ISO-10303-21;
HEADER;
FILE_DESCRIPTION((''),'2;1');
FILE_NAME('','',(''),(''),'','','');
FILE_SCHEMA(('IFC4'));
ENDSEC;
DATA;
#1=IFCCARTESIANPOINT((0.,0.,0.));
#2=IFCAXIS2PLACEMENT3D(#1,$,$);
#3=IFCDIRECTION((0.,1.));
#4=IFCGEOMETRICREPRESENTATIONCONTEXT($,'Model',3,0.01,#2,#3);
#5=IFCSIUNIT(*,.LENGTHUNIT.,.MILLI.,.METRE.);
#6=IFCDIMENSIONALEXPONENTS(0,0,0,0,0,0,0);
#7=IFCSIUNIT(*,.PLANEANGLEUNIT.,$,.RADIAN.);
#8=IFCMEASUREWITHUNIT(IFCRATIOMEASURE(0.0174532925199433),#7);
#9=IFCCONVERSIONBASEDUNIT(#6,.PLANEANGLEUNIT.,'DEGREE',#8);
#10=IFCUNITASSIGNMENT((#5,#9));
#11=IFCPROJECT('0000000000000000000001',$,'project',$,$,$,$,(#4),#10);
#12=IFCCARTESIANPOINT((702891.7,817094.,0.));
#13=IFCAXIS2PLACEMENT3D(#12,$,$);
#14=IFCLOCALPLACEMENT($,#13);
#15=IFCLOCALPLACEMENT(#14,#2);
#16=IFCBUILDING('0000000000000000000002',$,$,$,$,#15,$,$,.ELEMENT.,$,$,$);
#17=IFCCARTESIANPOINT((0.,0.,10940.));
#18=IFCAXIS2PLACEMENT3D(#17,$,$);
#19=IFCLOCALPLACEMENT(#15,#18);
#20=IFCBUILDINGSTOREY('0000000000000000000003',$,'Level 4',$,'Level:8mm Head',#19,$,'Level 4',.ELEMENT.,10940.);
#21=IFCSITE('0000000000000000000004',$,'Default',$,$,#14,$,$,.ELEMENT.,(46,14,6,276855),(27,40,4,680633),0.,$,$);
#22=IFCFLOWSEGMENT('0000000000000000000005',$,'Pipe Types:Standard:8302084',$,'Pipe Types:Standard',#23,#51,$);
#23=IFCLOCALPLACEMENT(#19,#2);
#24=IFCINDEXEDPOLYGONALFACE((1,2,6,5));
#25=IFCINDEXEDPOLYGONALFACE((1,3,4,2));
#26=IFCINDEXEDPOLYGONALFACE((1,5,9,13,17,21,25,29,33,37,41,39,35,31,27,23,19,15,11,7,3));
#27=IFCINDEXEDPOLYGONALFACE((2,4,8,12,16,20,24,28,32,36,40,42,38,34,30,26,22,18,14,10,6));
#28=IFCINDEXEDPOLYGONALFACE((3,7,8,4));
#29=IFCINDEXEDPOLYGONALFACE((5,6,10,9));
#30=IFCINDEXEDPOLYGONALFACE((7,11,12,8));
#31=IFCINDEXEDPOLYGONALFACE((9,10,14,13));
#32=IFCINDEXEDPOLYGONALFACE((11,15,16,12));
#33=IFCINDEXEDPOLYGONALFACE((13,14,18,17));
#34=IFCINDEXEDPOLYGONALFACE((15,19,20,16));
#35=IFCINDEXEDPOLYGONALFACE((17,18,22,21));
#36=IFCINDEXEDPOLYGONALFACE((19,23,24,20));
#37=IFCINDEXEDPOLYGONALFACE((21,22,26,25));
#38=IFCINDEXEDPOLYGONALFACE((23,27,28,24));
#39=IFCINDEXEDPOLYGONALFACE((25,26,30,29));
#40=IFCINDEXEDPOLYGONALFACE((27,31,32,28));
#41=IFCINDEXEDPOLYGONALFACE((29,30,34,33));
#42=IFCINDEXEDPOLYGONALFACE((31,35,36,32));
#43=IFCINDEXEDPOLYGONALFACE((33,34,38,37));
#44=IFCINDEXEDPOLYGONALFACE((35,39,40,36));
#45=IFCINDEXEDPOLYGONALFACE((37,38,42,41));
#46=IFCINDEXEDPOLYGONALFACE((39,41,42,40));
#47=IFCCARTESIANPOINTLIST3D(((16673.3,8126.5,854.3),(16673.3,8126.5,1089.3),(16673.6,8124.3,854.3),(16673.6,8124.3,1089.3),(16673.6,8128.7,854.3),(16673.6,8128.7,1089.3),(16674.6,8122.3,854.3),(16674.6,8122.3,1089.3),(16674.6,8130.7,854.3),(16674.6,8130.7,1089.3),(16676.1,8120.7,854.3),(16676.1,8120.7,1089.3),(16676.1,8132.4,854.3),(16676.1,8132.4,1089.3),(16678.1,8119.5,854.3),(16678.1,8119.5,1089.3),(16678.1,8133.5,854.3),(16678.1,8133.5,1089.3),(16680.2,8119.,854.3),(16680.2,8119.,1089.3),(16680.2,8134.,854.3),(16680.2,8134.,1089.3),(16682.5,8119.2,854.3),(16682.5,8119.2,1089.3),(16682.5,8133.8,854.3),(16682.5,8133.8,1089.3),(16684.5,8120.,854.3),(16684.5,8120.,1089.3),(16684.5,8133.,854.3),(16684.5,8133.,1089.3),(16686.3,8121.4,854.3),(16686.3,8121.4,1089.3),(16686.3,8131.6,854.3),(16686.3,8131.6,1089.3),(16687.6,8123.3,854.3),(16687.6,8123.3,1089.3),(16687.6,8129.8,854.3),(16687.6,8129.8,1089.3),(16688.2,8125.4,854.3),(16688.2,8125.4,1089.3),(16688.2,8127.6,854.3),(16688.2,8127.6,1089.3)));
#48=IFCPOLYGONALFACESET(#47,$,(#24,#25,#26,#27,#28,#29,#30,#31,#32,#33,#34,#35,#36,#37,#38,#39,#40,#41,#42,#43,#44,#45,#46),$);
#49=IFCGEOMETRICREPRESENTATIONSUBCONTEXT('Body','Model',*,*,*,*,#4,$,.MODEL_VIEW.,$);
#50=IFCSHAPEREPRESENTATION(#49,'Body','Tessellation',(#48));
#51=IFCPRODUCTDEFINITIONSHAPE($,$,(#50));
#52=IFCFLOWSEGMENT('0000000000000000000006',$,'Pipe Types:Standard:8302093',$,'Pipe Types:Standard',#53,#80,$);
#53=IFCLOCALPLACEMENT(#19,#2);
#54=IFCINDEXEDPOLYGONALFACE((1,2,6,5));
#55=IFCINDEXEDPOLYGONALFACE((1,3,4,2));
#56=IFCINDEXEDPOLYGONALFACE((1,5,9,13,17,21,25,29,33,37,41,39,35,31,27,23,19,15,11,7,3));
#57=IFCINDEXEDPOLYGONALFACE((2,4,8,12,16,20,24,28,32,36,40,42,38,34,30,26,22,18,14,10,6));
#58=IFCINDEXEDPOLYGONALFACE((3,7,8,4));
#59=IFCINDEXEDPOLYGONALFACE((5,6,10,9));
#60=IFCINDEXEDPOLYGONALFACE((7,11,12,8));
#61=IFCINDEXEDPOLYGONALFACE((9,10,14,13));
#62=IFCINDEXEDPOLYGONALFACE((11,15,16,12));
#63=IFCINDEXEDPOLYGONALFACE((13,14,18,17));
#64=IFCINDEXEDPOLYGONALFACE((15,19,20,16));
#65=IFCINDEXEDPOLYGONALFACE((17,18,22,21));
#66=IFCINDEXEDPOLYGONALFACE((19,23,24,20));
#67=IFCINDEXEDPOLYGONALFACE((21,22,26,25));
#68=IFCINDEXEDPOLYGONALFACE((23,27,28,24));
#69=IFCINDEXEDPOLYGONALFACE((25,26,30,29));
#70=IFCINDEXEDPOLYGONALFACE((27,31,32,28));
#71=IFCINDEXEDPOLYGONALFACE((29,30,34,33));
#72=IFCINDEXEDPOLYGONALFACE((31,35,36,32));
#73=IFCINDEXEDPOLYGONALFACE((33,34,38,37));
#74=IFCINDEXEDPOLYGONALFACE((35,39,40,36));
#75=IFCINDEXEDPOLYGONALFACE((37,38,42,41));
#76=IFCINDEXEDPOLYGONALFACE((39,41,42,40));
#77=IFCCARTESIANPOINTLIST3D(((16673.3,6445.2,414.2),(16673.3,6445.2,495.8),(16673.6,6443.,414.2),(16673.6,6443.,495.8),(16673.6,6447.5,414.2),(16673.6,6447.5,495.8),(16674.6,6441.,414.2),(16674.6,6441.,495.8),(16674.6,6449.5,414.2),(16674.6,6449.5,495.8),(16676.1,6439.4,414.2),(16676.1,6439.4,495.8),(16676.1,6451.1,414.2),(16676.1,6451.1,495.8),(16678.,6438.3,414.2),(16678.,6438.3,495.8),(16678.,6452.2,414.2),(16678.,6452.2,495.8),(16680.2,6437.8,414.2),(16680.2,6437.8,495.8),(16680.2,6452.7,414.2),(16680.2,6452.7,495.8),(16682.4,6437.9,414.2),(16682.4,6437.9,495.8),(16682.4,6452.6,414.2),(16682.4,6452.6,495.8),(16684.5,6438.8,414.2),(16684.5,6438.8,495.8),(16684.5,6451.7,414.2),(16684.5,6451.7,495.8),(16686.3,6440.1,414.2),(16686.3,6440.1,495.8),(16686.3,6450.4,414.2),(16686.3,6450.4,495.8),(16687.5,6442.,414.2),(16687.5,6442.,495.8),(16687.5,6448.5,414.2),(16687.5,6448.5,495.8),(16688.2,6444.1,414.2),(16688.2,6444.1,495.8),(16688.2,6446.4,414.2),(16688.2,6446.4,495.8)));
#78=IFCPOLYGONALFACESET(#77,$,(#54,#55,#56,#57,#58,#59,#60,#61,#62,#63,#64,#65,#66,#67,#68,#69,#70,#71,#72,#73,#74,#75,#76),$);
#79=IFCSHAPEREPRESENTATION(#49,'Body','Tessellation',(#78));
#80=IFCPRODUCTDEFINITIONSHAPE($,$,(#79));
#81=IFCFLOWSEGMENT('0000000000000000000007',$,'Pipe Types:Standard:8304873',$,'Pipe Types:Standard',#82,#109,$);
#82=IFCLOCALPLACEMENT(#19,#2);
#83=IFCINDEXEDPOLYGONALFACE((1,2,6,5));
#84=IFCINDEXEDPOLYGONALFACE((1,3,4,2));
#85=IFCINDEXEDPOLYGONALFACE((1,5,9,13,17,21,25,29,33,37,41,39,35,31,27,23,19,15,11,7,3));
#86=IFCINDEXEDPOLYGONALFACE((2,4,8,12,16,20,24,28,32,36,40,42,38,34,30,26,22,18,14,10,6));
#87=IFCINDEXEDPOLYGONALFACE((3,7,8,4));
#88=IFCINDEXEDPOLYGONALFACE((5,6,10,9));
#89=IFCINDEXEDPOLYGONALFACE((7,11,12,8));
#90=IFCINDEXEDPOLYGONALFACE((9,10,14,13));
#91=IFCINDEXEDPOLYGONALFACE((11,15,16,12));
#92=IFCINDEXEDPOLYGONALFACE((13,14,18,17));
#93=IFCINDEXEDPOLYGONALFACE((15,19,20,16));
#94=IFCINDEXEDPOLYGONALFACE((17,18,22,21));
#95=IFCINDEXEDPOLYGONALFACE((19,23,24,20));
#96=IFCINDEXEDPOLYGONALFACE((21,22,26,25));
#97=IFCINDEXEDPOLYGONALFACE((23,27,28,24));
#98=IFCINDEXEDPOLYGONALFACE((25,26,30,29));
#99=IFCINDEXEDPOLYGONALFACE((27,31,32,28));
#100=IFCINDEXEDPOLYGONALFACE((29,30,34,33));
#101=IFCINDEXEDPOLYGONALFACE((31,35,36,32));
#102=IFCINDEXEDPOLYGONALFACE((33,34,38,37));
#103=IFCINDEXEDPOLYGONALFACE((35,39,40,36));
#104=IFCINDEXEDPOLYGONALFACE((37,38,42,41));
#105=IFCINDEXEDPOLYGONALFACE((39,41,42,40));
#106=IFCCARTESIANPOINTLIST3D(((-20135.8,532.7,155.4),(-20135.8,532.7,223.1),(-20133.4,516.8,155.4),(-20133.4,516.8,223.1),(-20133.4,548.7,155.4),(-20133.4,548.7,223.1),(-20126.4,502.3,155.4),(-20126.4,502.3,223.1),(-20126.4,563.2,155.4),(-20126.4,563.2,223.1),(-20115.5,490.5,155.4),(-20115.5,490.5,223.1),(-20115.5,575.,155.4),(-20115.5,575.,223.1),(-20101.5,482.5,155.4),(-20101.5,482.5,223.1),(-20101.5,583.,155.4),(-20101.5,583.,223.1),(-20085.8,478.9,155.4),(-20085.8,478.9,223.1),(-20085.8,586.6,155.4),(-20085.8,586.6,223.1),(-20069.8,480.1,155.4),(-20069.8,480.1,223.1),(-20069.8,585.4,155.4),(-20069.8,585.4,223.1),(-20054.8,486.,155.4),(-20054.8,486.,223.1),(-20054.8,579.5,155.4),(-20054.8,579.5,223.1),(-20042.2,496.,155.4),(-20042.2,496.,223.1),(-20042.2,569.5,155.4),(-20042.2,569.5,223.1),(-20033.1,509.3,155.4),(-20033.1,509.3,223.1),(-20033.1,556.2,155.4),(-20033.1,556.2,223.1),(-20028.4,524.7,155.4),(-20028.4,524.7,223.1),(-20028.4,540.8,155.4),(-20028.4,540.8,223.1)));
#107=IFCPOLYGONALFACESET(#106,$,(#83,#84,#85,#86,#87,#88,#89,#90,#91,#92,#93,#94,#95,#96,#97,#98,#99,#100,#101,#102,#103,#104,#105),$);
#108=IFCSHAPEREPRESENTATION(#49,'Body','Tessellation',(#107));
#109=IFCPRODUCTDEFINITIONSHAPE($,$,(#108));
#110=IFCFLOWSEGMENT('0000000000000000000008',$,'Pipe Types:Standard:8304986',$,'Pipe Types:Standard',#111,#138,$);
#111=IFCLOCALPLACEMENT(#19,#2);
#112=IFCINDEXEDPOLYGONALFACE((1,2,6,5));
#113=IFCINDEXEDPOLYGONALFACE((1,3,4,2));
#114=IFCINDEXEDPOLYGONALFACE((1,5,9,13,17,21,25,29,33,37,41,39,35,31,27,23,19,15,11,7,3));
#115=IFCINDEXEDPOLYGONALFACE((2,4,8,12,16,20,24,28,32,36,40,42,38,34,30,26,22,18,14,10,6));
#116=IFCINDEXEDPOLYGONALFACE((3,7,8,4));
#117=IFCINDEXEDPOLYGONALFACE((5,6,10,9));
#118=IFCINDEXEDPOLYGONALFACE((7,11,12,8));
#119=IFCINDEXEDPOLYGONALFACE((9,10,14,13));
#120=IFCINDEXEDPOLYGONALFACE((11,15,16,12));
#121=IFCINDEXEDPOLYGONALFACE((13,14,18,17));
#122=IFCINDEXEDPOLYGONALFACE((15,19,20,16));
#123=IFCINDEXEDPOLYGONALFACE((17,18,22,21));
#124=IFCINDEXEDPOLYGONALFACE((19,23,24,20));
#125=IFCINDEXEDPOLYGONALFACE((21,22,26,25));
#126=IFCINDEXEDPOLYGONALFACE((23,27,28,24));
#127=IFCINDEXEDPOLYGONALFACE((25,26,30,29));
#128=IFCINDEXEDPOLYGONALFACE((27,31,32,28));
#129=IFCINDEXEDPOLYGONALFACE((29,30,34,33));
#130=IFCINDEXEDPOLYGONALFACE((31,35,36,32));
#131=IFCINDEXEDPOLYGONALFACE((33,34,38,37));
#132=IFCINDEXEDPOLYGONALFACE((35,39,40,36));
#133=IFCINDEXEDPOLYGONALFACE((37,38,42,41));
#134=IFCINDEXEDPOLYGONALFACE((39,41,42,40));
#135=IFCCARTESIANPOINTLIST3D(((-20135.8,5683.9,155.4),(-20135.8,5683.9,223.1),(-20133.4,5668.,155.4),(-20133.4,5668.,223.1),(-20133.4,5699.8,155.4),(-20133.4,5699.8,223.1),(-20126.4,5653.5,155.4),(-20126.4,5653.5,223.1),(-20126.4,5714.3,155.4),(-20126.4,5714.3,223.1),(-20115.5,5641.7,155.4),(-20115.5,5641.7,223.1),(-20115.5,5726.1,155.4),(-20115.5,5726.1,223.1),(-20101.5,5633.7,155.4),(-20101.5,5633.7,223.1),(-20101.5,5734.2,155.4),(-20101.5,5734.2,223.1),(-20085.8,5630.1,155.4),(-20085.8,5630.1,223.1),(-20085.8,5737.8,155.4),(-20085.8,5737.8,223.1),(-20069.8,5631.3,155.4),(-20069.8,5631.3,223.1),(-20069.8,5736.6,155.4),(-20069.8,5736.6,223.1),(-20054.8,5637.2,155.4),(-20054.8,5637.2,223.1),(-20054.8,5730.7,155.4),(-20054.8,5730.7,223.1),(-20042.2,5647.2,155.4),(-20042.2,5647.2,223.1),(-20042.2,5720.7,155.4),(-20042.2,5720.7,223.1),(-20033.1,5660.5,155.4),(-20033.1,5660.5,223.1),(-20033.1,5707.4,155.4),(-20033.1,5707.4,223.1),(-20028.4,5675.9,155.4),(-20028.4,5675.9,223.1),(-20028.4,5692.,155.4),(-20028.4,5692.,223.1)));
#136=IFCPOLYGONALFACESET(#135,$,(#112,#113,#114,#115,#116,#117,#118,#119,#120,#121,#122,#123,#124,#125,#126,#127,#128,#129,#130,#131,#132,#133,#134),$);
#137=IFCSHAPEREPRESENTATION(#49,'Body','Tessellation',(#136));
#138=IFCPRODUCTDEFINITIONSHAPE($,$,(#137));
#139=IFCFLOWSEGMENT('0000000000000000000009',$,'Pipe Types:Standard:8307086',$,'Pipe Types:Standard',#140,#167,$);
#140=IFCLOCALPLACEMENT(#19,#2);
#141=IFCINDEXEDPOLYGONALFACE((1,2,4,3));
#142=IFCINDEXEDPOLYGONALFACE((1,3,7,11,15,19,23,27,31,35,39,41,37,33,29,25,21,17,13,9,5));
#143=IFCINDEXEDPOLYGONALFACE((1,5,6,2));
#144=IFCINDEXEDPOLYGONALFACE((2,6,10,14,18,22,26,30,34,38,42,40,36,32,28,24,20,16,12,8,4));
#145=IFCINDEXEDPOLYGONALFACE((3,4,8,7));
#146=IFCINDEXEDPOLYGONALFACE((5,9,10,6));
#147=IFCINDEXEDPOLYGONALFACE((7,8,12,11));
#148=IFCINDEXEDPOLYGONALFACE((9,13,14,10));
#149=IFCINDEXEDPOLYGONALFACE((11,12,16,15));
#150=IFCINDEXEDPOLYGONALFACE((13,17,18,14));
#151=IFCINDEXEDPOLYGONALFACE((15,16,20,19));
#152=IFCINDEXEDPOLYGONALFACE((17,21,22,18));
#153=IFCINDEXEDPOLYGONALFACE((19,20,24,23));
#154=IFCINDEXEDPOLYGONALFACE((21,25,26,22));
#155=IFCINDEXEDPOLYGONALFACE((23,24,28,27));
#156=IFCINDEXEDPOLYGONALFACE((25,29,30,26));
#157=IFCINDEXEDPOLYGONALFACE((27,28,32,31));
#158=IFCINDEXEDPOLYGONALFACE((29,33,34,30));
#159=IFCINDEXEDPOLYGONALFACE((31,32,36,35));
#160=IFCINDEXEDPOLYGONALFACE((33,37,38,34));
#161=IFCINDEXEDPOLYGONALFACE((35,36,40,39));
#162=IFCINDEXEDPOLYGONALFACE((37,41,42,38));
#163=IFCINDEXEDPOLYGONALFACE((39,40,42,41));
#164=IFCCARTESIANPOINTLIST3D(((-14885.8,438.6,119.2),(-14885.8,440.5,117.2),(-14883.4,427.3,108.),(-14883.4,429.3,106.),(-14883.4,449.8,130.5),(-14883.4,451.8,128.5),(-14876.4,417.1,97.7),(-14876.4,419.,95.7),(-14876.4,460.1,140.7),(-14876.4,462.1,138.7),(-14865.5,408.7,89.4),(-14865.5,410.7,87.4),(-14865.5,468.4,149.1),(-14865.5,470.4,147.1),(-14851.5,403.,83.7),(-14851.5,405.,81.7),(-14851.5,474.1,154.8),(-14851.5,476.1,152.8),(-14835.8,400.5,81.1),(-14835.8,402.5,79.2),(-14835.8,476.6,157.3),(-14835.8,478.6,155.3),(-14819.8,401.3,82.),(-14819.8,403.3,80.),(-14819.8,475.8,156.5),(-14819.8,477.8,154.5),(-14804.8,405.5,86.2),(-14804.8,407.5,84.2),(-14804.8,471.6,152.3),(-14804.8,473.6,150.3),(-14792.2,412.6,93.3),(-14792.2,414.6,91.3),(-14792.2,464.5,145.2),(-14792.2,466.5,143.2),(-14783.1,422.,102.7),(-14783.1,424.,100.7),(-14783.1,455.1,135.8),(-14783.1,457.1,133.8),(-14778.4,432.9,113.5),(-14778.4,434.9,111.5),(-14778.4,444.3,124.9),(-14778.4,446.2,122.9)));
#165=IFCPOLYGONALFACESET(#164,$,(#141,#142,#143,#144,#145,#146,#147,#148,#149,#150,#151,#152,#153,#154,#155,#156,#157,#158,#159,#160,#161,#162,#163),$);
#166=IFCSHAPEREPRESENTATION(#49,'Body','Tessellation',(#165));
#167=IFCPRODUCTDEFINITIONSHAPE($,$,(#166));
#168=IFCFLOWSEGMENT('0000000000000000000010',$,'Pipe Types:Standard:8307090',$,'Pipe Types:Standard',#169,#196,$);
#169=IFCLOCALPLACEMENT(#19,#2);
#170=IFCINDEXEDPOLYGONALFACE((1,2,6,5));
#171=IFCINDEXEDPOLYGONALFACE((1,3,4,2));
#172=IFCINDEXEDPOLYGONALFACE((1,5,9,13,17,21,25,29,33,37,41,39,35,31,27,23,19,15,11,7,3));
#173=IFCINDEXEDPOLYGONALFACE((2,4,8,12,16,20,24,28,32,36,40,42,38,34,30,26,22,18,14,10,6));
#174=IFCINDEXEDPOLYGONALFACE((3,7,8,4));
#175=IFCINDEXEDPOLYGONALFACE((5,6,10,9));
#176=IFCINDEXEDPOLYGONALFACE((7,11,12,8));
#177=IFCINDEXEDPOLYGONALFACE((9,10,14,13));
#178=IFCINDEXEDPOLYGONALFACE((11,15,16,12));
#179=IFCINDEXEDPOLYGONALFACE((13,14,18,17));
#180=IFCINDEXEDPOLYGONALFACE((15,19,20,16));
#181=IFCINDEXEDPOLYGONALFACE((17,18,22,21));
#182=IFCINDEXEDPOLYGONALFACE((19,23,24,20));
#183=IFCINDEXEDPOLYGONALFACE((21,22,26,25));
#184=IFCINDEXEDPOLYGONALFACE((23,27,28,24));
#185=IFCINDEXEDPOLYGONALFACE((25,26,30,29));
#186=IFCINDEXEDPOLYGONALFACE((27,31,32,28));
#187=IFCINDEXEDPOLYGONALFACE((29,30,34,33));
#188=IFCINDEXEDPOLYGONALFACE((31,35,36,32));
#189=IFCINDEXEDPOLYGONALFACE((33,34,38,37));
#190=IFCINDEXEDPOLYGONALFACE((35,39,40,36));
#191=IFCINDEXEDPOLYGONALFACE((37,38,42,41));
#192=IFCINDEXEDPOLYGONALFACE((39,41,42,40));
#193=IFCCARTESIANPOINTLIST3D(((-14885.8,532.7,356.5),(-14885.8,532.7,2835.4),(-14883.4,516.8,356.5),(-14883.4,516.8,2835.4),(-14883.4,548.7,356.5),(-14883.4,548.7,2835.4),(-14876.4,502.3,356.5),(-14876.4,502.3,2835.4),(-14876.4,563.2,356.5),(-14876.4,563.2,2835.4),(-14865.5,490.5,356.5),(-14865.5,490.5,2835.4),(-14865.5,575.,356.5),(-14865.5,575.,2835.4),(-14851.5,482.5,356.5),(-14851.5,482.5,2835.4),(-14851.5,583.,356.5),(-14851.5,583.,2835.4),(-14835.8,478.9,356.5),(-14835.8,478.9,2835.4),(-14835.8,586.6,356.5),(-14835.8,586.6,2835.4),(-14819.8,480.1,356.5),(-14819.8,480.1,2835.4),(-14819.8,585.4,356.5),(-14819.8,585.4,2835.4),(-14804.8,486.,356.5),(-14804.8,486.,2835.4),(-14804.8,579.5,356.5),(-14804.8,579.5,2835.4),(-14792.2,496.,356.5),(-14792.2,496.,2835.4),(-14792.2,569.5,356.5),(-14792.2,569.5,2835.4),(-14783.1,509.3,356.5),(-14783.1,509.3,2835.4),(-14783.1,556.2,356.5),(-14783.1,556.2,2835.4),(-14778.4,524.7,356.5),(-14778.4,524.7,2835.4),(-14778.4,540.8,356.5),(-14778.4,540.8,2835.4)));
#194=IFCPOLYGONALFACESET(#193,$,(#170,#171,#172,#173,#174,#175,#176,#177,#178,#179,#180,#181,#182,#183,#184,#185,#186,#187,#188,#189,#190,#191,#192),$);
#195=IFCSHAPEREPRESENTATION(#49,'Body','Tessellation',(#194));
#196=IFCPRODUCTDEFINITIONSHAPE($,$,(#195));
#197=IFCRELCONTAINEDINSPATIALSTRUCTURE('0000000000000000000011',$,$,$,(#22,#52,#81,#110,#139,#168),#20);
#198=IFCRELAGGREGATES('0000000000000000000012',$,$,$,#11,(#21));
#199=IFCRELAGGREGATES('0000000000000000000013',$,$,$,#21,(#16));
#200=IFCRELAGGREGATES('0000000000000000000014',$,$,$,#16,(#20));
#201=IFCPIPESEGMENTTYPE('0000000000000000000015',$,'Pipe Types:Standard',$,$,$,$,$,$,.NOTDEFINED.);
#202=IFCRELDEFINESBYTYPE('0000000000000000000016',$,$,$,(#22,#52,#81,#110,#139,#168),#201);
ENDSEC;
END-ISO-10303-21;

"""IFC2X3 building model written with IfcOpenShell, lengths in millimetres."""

from ifc_helpers import new_model, entity, si_unit, converted_unit, direction, frame, frame_2d, origin, origin_2d_with_axis, place, context, subcontext, project, spatial, circle, extrude, type_object, element, save


model = new_model("IFC2X3")

# Units and contexts
model_context = context("Model", 3, precision=0.01, world=origin(), true_north=direction((0.0, 1.0)))
body_context = subcontext(model_context, "Body", "Model", "MODEL_VIEW")
ifc_project = project(units=[si_unit("LENGTHUNIT", "METRE", prefix="MILLI"), converted_unit("PLANEANGLEUNIT", "DEGREE", entity("IfcRatioMeasure", 0.0174532925199433), si_unit("PLANEANGLEUNIT", "RADIAN"), dimensions=[0, 0, 0, 0, 0, 0, 0])], contexts=[model_context])

# Site, building, storey
site_placement = place(None, frame((702891.7, 817094.0, 0.0)))
site = spatial("IfcSite", under=ifc_project, at=site_placement, Name="Default", CompositionType="ELEMENT", RefLatitude=(46, 14, 6, 276855), RefLongitude=(27, 40, 4, 680633), RefElevation=0.0)
building_placement = place(site_placement, origin())
building = spatial("IfcBuilding", under=site, at=building_placement, CompositionType="ELEMENT")
storey_placement = place(building_placement, frame((0.0, 0.0, 10940.0)))
storey = spatial("IfcBuildingStorey", under=building, at=storey_placement, Name="Level 4", ObjectType="Level:8mm Head", LongName="Level 4", CompositionType="ELEMENT", Elevation=10940.0)

# Flow segments
pipe_segment_type = type_object("IfcPipeSegmentType", Name="Pipe Types:Standard", PredefinedType="NOTDEFINED")
flow_segment_1_placement = place(storey_placement, origin())
element("IfcFlowSegment", 1, at=flow_segment_1_placement, inside=storey, type_object=pipe_segment_type, Name="Pipe Types:Standard:8302084", ObjectType="Pipe Types:Standard", context=body_context, shape_type="SweptSolid", body=[
    extrude(circle(Radius=7.5, at=origin_2d_with_axis()), frame((16680.8, 8126.5, 854.3), z_axis=(0.0, 0.0, 1.0), x_axis=(-1.0, 0.0, 0.0)), (0.0, 0.0, 1.0), 235.0),
])
flow_segment_2_placement = place(storey_placement, origin())
element("IfcFlowSegment", 2, at=flow_segment_2_placement, inside=storey, type_object=pipe_segment_type, Name="Pipe Types:Standard:8302093", ObjectType="Pipe Types:Standard", context=body_context, shape_type="SweptSolid", body=[
    extrude(circle(Radius=7.5, at=origin_2d_with_axis()), frame((16680.8, 6445.2, 414.2), z_axis=(0.0, 0.0, 1.0), x_axis=(-1.0, 0.0, 0.0)), (0.0, 0.0, 1.0), 81.6),
])
flow_segment_3_placement = place(storey_placement, origin())
element("IfcFlowSegment", 3, at=flow_segment_3_placement, inside=storey, type_object=pipe_segment_type, Name="Pipe Types:Standard:8304873", ObjectType="Pipe Types:Standard", context=body_context, shape_type="SweptSolid", body=[
    extrude(circle(Radius=54.0, at=frame_2d((0.0, 0.0), x_axis=(1.0, 0.0))), frame((-20081.8, 532.7, 155.4), z_axis=(0.0, 0.0, 1.0), x_axis=(-1.0, 0.0, 0.0)), (0.0, 0.0, 1.0), 67.6),
])
flow_segment_4_placement = place(storey_placement, origin())
element("IfcFlowSegment", 4, at=flow_segment_4_placement, inside=storey, type_object=pipe_segment_type, Name="Pipe Types:Standard:8304986", ObjectType="Pipe Types:Standard", context=body_context, shape_type="SweptSolid", body=[
    extrude(circle(Radius=54.0, at=origin_2d_with_axis()), frame((-20081.8, 5683.9, 155.4), z_axis=(0.0, 0.0, 1.0), x_axis=(-1.0, 0.0, 0.0)), (0.0, 0.0, 1.0), 67.6),
])
flow_segment_5_placement = place(storey_placement, origin())
element("IfcFlowSegment", 5, at=flow_segment_5_placement, inside=storey, type_object=pipe_segment_type, Name="Pipe Types:Standard:8307086", ObjectType="Pipe Types:Standard", context=body_context, shape_type="SweptSolid", body=[
    extrude(circle(Radius=54.0, at=frame_2d((0.0, 0.0), x_axis=(1.0, 0.0))), frame((-14831.8, 438.6, 119.2), z_axis=(0.0, 0.707107, -0.707107), x_axis=(-1.0, 0.0, 0.0)), (0.0, 0.0, 1.0), 2.8),
])
flow_segment_6_placement = place(storey_placement, origin())
element("IfcFlowSegment", 6, at=flow_segment_6_placement, inside=storey, type_object=pipe_segment_type, Name="Pipe Types:Standard:8307090", ObjectType="Pipe Types:Standard", context=body_context, shape_type="SweptSolid", body=[
    extrude(circle(Radius=54.0, at=frame_2d((0.0, 0.0), x_axis=(1.0, 0.0))), frame((-14831.8, 532.7, 356.5), z_axis=(0.0, 0.0, 1.0), x_axis=(-1.0, 0.0, 0.0)), (0.0, 0.0, 1.0), 2479.0),
])

save(model, "model.ifc")
